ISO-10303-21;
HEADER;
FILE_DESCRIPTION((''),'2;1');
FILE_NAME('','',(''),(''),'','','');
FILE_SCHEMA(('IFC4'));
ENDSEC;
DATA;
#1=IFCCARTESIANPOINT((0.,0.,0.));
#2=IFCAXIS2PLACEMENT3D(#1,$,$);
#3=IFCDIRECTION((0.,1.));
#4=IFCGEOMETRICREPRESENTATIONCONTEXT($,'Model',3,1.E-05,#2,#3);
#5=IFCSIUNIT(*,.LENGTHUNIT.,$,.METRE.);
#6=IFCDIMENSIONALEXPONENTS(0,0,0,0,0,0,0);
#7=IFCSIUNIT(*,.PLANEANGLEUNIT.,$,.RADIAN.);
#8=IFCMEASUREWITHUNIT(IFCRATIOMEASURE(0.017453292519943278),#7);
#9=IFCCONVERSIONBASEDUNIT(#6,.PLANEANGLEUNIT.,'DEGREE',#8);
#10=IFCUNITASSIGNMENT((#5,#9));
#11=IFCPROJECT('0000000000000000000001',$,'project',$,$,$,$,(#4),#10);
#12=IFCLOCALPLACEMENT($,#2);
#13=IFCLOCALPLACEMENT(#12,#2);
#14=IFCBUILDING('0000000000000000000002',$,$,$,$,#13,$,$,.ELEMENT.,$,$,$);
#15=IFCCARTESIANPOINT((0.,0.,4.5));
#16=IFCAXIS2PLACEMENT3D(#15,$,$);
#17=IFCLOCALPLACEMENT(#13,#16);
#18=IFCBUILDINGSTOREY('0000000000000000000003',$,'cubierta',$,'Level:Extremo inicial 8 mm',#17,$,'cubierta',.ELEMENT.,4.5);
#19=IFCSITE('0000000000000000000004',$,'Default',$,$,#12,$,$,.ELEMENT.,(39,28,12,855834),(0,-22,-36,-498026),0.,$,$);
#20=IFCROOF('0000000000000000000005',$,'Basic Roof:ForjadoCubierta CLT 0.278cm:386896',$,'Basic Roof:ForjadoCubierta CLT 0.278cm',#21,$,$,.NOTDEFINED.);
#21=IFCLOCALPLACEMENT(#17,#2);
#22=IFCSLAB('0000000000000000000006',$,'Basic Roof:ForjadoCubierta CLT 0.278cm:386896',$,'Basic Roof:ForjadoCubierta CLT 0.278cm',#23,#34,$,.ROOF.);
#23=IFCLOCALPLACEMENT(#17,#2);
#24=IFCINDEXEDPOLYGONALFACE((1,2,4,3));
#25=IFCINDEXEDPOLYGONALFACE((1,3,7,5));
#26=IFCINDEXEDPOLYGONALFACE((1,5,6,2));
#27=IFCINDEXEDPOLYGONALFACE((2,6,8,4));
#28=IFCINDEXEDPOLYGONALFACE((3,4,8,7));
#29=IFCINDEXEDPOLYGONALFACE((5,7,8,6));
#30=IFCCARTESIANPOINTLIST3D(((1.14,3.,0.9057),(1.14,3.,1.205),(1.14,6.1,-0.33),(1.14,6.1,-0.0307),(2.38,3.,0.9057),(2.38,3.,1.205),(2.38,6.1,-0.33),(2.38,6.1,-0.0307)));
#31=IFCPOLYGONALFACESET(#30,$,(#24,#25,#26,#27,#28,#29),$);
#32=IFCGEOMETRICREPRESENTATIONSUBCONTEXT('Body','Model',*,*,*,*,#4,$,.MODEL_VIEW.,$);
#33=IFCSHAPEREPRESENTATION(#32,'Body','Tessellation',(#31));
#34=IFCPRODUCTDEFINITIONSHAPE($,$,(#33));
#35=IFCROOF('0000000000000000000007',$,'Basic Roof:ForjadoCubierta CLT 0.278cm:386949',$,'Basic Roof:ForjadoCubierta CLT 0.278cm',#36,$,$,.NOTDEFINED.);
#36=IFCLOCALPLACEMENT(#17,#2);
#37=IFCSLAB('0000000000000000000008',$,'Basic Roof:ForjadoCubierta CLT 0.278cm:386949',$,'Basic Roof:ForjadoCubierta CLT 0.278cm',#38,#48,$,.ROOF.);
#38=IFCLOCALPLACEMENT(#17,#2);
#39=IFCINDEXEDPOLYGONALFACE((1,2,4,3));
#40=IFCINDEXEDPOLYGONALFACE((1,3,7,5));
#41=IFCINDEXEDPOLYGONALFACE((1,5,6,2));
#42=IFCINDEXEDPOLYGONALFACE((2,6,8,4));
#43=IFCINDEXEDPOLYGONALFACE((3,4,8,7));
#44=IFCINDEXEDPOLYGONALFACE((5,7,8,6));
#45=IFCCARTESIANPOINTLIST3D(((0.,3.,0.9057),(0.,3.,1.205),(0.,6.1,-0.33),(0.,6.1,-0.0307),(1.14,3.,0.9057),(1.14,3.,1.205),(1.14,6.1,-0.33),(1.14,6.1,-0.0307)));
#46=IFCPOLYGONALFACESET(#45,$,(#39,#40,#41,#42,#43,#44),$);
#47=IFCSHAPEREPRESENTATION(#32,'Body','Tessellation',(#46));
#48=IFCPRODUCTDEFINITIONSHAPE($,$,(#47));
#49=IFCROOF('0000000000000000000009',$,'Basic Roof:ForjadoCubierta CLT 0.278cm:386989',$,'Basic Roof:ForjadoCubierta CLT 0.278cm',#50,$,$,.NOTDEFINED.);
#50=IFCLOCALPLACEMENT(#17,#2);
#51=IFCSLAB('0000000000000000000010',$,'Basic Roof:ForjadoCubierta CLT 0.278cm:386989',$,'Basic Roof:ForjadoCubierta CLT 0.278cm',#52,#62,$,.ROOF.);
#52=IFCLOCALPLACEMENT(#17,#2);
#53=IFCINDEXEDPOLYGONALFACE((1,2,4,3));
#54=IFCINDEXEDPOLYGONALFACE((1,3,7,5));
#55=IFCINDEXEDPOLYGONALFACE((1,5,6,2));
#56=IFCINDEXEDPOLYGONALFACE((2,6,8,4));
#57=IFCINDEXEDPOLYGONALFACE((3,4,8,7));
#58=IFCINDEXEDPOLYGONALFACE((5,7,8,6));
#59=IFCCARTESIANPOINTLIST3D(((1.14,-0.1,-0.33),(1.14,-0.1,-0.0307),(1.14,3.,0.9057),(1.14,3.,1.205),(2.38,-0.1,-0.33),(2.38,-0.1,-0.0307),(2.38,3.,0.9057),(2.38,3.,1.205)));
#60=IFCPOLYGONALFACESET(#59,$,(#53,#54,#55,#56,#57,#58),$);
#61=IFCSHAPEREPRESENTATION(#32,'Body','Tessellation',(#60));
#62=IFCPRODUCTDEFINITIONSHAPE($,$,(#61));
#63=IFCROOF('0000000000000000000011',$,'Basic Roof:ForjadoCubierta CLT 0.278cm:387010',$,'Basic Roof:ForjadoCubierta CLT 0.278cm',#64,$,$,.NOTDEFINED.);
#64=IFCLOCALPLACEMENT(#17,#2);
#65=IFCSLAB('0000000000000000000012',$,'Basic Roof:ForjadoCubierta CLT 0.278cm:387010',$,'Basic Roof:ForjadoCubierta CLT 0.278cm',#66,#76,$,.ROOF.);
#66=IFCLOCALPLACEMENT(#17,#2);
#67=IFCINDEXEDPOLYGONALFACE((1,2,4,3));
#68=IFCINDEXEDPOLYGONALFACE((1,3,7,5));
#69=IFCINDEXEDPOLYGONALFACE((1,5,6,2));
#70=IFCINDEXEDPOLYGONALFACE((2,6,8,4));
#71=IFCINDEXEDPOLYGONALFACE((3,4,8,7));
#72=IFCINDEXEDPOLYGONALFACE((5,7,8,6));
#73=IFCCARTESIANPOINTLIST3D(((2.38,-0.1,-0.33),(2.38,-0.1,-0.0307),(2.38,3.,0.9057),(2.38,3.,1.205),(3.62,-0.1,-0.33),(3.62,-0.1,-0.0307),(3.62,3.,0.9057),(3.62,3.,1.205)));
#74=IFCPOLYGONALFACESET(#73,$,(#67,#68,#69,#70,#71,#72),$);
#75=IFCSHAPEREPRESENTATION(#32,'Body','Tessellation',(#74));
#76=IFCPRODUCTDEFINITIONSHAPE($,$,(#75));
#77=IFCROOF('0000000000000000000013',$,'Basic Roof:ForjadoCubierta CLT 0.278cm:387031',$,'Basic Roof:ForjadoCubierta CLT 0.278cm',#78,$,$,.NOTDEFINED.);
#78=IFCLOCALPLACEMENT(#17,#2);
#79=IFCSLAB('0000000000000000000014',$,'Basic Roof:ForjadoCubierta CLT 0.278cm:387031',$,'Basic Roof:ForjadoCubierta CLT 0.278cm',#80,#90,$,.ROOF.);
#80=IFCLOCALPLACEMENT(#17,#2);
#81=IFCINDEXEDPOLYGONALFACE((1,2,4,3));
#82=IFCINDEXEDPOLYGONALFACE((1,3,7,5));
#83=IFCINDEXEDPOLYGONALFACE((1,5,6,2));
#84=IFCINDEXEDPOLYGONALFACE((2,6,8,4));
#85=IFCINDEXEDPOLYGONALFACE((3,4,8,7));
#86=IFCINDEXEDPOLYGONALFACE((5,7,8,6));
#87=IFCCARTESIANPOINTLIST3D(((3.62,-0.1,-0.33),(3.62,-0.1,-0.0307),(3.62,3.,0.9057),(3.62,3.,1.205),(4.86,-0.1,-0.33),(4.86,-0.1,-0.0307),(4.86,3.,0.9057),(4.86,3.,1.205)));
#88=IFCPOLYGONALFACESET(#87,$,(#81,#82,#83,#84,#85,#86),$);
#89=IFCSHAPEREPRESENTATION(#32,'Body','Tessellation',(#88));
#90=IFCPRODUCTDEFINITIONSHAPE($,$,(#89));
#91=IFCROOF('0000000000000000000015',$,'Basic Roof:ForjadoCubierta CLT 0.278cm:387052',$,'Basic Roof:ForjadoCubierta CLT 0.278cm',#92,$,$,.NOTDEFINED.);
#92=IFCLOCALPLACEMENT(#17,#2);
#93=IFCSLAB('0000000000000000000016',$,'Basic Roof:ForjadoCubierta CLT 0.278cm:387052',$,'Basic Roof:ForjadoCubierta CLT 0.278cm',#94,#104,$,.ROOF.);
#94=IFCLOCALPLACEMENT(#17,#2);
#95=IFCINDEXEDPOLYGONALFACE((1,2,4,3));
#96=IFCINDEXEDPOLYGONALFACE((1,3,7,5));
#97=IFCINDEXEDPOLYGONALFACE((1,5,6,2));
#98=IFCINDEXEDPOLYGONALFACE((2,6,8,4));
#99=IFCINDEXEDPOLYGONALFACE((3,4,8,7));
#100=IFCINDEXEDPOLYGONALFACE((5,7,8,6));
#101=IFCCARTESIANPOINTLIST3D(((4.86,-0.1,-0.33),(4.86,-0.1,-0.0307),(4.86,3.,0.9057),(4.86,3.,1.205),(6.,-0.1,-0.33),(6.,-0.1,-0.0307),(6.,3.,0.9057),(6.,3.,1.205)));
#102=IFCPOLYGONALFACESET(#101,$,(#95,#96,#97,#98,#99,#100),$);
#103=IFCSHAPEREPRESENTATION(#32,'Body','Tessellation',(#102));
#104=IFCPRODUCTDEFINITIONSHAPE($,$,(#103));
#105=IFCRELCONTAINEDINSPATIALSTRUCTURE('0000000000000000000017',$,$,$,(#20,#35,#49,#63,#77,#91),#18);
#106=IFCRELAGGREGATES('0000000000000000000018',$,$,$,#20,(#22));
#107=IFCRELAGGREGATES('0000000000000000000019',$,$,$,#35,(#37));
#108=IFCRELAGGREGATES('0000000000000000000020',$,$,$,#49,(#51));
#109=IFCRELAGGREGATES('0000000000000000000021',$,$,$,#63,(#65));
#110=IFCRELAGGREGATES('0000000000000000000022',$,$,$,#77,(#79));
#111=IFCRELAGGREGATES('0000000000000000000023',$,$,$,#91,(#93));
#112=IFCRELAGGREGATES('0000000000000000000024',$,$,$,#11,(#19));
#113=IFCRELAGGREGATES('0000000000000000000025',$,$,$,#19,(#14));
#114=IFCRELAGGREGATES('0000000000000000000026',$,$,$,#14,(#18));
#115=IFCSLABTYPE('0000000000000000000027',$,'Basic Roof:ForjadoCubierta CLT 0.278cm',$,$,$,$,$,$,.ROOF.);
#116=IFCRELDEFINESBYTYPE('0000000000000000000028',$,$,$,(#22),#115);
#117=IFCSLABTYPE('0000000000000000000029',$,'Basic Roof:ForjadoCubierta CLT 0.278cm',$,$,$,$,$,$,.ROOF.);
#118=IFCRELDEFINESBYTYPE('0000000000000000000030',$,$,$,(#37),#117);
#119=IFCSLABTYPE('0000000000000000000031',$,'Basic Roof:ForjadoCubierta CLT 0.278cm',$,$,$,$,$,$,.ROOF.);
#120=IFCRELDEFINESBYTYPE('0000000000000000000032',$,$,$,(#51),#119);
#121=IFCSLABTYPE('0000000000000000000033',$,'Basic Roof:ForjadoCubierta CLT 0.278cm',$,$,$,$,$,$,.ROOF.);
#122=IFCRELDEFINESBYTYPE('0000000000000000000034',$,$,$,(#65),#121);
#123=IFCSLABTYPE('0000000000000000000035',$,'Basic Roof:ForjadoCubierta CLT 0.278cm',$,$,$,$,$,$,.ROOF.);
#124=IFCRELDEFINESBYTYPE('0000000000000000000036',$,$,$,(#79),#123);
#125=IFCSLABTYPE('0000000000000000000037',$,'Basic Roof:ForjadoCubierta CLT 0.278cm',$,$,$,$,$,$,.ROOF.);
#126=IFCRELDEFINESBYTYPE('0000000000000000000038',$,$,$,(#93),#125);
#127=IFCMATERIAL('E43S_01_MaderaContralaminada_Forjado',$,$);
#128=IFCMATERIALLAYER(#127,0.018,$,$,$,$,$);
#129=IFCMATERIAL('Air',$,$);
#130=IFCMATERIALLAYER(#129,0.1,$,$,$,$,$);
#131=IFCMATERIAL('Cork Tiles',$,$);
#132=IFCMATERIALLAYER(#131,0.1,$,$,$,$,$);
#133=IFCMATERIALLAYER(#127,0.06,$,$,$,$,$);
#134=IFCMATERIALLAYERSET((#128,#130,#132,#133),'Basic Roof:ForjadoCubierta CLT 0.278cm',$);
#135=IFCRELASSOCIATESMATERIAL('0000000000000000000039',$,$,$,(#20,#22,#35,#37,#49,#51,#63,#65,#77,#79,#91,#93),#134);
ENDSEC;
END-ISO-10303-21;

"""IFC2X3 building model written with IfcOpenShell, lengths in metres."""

from ifc_helpers import new_model, entity, si_unit, converted_unit, direction, frame, frame_2d, origin, place, context, subcontext, project, spatial, rectangle, extrude, material, layer, layer_set, type_object, element, aggregate, save


model = new_model("IFC2X3")

# Units and contexts
model_context = context("Model", 3, precision=1e-05, world=origin(), true_north=direction((0.0, 1.0)))
body_context = subcontext(model_context, "Body", "Model", "MODEL_VIEW")
ifc_project = project(units=[si_unit("LENGTHUNIT", "METRE"), converted_unit("PLANEANGLEUNIT", "DEGREE", entity("IfcRatioMeasure", 0.017453292519943278), si_unit("PLANEANGLEUNIT", "RADIAN"), dimensions=[0, 0, 0, 0, 0, 0, 0])], contexts=[model_context])

# Site, building, storey
site_placement = place(None, origin())
site = spatial("IfcSite", under=ifc_project, at=site_placement, Name="Default", CompositionType="ELEMENT", RefLatitude=(39, 28, 12, 855834), RefLongitude=(0, -22, -36, -498026), RefElevation=0.0)
building_placement = place(site_placement, origin())
building = spatial("IfcBuilding", under=site, at=building_placement, CompositionType="ELEMENT")
storey_placement = place(building_placement, frame((0.0, 0.0, 4.5)))
storey = spatial("IfcBuildingStorey", under=building, at=storey_placement, Name="cubierta", ObjectType="Level:Extremo inicial 8 mm", LongName="cubierta", CompositionType="ELEMENT", Elevation=4.5)

# Roofs, slabs
ifc_material_1 = material(Name="E43S_01_MaderaContralaminada_Forjado")
ifc_layer_1 = layer(ifc_material_1, 0.018)
ifc_material_2 = material(Name="Air")
ifc_layer_2 = layer(ifc_material_2, 0.1)
ifc_material_3 = material(Name="Cork Tiles")
ifc_layer_3 = layer(ifc_material_3, 0.1)
ifc_layer_4 = layer(ifc_material_1, 0.06)
ifc_layer_set_1 = layer_set([ifc_layer_1, ifc_layer_2, ifc_layer_3, ifc_layer_4], Name="Basic Roof:ForjadoCubierta CLT 0.278cm")
roof_1_placement = place(storey_placement, frame((1.14, 3.0, -0.33)))
roof_1 = element("IfcRoof", 1, at=roof_1_placement, inside=storey, material=ifc_layer_set_1, Name="Basic Roof:ForjadoCubierta CLT 0.278cm:386896", ObjectType="Basic Roof:ForjadoCubierta CLT 0.278cm", ShapeType="NOTDEFINED")
slab_type_1 = type_object("IfcSlabType", Name="Basic Roof:ForjadoCubierta CLT 0.278cm", PredefinedType="ROOF")
slab_1_placement = place(roof_1_placement, origin())
slab_1 = element("IfcSlab", 2, at=slab_1_placement, type_object=slab_type_1, material=ifc_layer_set_1, Name="Basic Roof:ForjadoCubierta CLT 0.278cm:386896", ObjectType="Basic Roof:ForjadoCubierta CLT 0.278cm", PredefinedType="ROOF", context=body_context, shape_type="SweptSolid", body=[
    extrude(rectangle(XDim=3.3372, YDim=1.24, at=frame_2d((0.0, 0.0), x_axis=(0.0, 1.0))), frame((0.62, 1.55, 0.6179), z_axis=(0.0, 0.370288, 0.928917), x_axis=(1.0, 0.0, 0.0)), (0.0, -0.370288, 0.928917), 0.2993),
])
aggregate(roof_1, [slab_1])
roof_2_placement = place(storey_placement, frame((0.0, 3.0, -0.33)))
roof_2 = element("IfcRoof", 3, at=roof_2_placement, inside=storey, material=ifc_layer_set_1, Name="Basic Roof:ForjadoCubierta CLT 0.278cm:386949", ObjectType="Basic Roof:ForjadoCubierta CLT 0.278cm", ShapeType="NOTDEFINED")
slab_type_2 = type_object("IfcSlabType", Name="Basic Roof:ForjadoCubierta CLT 0.278cm", PredefinedType="ROOF")
slab_2_placement = place(roof_2_placement, origin())
slab_2 = element("IfcSlab", 4, at=slab_2_placement, type_object=slab_type_2, material=ifc_layer_set_1, Name="Basic Roof:ForjadoCubierta CLT 0.278cm:386949", ObjectType="Basic Roof:ForjadoCubierta CLT 0.278cm", PredefinedType="ROOF", context=body_context, shape_type="SweptSolid", body=[
    extrude(rectangle(XDim=3.3372, YDim=1.14, at=frame_2d((0.0, 0.0), x_axis=(0.0, 1.0))), frame((0.57, 1.55, 0.6179), z_axis=(0.0, 0.370288, 0.928917), x_axis=(1.0, 0.0, 0.0)), (0.0, -0.370288, 0.928917), 0.2993),
])
aggregate(roof_2, [slab_2])
roof_3_placement = place(storey_placement, frame((1.14, -0.1, -0.33)))
roof_3 = element("IfcRoof", 5, at=roof_3_placement, inside=storey, material=ifc_layer_set_1, Name="Basic Roof:ForjadoCubierta CLT 0.278cm:386989", ObjectType="Basic Roof:ForjadoCubierta CLT 0.278cm", ShapeType="NOTDEFINED")
slab_type_3 = type_object("IfcSlabType", Name="Basic Roof:ForjadoCubierta CLT 0.278cm", PredefinedType="ROOF")
slab_3_placement = place(roof_3_placement, origin())
slab_3 = element("IfcSlab", 6, at=slab_3_placement, type_object=slab_type_3, material=ifc_layer_set_1, Name="Basic Roof:ForjadoCubierta CLT 0.278cm:386989", ObjectType="Basic Roof:ForjadoCubierta CLT 0.278cm", PredefinedType="ROOF", context=body_context, shape_type="SweptSolid", body=[
    extrude(rectangle(XDim=3.3372, YDim=1.24, at=frame_2d((0.0, 0.0), x_axis=(0.0, -1.0))), frame((0.62, 1.55, 0.6179), z_axis=(0.0, -0.370288, 0.928917), x_axis=(1.0, 0.0, 0.0)), (0.0, 0.370288, 0.928917), 0.2993),
])
aggregate(roof_3, [slab_3])
roof_4_placement = place(storey_placement, frame((2.38, -0.1, -0.33)))
roof_4 = element("IfcRoof", 7, at=roof_4_placement, inside=storey, material=ifc_layer_set_1, Name="Basic Roof:ForjadoCubierta CLT 0.278cm:387010", ObjectType="Basic Roof:ForjadoCubierta CLT 0.278cm", ShapeType="NOTDEFINED")
slab_type_4 = type_object("IfcSlabType", Name="Basic Roof:ForjadoCubierta CLT 0.278cm", PredefinedType="ROOF")
slab_4_placement = place(roof_4_placement, origin())
slab_4 = element("IfcSlab", 8, at=slab_4_placement, type_object=slab_type_4, material=ifc_layer_set_1, Name="Basic Roof:ForjadoCubierta CLT 0.278cm:387010", ObjectType="Basic Roof:ForjadoCubierta CLT 0.278cm", PredefinedType="ROOF", context=body_context, shape_type="SweptSolid", body=[
    extrude(rectangle(XDim=3.3372, YDim=1.24, at=frame_2d((0.0, 0.0), x_axis=(0.0, -1.0))), frame((0.62, 1.55, 0.6179), z_axis=(0.0, -0.370288, 0.928917), x_axis=(1.0, 0.0, 0.0)), (0.0, 0.370288, 0.928917), 0.2993),
])
aggregate(roof_4, [slab_4])
roof_5_placement = place(storey_placement, frame((3.62, -0.1, -0.33)))
roof_5 = element("IfcRoof", 9, at=roof_5_placement, inside=storey, material=ifc_layer_set_1, Name="Basic Roof:ForjadoCubierta CLT 0.278cm:387031", ObjectType="Basic Roof:ForjadoCubierta CLT 0.278cm", ShapeType="NOTDEFINED")
slab_type_5 = type_object("IfcSlabType", Name="Basic Roof:ForjadoCubierta CLT 0.278cm", PredefinedType="ROOF")
slab_5_placement = place(roof_5_placement, origin())
slab_5 = element("IfcSlab", 10, at=slab_5_placement, type_object=slab_type_5, material=ifc_layer_set_1, Name="Basic Roof:ForjadoCubierta CLT 0.278cm:387031", ObjectType="Basic Roof:ForjadoCubierta CLT 0.278cm", PredefinedType="ROOF", context=body_context, shape_type="SweptSolid", body=[
    extrude(rectangle(XDim=3.3372, YDim=1.24, at=frame_2d((0.0, 0.0), x_axis=(0.0, -1.0))), frame((0.62, 1.55, 0.6179), z_axis=(0.0, -0.370288, 0.928917), x_axis=(1.0, 0.0, 0.0)), (0.0, 0.370288, 0.928917), 0.2993),
])
aggregate(roof_5, [slab_5])
roof_6_placement = place(storey_placement, frame((4.86, -0.1, -0.33)))
roof_6 = element("IfcRoof", 11, at=roof_6_placement, inside=storey, material=ifc_layer_set_1, Name="Basic Roof:ForjadoCubierta CLT 0.278cm:387052", ObjectType="Basic Roof:ForjadoCubierta CLT 0.278cm", ShapeType="NOTDEFINED")
slab_type_6 = type_object("IfcSlabType", Name="Basic Roof:ForjadoCubierta CLT 0.278cm", PredefinedType="ROOF")
slab_6_placement = place(roof_6_placement, origin())
slab_6 = element("IfcSlab", 12, at=slab_6_placement, type_object=slab_type_6, material=ifc_layer_set_1, Name="Basic Roof:ForjadoCubierta CLT 0.278cm:387052", ObjectType="Basic Roof:ForjadoCubierta CLT 0.278cm", PredefinedType="ROOF", context=body_context, shape_type="SweptSolid", body=[
    extrude(rectangle(XDim=3.3372, YDim=1.14, at=frame_2d((0.0, 0.0), x_axis=(0.0, -1.0))), frame((0.57, 1.55, 0.6179), z_axis=(0.0, -0.370288, 0.928917), x_axis=(1.0, 0.0, 0.0)), (0.0, 0.370288, 0.928917), 0.2993),
])
aggregate(roof_6, [slab_6])

save(model, "model.ifc")
